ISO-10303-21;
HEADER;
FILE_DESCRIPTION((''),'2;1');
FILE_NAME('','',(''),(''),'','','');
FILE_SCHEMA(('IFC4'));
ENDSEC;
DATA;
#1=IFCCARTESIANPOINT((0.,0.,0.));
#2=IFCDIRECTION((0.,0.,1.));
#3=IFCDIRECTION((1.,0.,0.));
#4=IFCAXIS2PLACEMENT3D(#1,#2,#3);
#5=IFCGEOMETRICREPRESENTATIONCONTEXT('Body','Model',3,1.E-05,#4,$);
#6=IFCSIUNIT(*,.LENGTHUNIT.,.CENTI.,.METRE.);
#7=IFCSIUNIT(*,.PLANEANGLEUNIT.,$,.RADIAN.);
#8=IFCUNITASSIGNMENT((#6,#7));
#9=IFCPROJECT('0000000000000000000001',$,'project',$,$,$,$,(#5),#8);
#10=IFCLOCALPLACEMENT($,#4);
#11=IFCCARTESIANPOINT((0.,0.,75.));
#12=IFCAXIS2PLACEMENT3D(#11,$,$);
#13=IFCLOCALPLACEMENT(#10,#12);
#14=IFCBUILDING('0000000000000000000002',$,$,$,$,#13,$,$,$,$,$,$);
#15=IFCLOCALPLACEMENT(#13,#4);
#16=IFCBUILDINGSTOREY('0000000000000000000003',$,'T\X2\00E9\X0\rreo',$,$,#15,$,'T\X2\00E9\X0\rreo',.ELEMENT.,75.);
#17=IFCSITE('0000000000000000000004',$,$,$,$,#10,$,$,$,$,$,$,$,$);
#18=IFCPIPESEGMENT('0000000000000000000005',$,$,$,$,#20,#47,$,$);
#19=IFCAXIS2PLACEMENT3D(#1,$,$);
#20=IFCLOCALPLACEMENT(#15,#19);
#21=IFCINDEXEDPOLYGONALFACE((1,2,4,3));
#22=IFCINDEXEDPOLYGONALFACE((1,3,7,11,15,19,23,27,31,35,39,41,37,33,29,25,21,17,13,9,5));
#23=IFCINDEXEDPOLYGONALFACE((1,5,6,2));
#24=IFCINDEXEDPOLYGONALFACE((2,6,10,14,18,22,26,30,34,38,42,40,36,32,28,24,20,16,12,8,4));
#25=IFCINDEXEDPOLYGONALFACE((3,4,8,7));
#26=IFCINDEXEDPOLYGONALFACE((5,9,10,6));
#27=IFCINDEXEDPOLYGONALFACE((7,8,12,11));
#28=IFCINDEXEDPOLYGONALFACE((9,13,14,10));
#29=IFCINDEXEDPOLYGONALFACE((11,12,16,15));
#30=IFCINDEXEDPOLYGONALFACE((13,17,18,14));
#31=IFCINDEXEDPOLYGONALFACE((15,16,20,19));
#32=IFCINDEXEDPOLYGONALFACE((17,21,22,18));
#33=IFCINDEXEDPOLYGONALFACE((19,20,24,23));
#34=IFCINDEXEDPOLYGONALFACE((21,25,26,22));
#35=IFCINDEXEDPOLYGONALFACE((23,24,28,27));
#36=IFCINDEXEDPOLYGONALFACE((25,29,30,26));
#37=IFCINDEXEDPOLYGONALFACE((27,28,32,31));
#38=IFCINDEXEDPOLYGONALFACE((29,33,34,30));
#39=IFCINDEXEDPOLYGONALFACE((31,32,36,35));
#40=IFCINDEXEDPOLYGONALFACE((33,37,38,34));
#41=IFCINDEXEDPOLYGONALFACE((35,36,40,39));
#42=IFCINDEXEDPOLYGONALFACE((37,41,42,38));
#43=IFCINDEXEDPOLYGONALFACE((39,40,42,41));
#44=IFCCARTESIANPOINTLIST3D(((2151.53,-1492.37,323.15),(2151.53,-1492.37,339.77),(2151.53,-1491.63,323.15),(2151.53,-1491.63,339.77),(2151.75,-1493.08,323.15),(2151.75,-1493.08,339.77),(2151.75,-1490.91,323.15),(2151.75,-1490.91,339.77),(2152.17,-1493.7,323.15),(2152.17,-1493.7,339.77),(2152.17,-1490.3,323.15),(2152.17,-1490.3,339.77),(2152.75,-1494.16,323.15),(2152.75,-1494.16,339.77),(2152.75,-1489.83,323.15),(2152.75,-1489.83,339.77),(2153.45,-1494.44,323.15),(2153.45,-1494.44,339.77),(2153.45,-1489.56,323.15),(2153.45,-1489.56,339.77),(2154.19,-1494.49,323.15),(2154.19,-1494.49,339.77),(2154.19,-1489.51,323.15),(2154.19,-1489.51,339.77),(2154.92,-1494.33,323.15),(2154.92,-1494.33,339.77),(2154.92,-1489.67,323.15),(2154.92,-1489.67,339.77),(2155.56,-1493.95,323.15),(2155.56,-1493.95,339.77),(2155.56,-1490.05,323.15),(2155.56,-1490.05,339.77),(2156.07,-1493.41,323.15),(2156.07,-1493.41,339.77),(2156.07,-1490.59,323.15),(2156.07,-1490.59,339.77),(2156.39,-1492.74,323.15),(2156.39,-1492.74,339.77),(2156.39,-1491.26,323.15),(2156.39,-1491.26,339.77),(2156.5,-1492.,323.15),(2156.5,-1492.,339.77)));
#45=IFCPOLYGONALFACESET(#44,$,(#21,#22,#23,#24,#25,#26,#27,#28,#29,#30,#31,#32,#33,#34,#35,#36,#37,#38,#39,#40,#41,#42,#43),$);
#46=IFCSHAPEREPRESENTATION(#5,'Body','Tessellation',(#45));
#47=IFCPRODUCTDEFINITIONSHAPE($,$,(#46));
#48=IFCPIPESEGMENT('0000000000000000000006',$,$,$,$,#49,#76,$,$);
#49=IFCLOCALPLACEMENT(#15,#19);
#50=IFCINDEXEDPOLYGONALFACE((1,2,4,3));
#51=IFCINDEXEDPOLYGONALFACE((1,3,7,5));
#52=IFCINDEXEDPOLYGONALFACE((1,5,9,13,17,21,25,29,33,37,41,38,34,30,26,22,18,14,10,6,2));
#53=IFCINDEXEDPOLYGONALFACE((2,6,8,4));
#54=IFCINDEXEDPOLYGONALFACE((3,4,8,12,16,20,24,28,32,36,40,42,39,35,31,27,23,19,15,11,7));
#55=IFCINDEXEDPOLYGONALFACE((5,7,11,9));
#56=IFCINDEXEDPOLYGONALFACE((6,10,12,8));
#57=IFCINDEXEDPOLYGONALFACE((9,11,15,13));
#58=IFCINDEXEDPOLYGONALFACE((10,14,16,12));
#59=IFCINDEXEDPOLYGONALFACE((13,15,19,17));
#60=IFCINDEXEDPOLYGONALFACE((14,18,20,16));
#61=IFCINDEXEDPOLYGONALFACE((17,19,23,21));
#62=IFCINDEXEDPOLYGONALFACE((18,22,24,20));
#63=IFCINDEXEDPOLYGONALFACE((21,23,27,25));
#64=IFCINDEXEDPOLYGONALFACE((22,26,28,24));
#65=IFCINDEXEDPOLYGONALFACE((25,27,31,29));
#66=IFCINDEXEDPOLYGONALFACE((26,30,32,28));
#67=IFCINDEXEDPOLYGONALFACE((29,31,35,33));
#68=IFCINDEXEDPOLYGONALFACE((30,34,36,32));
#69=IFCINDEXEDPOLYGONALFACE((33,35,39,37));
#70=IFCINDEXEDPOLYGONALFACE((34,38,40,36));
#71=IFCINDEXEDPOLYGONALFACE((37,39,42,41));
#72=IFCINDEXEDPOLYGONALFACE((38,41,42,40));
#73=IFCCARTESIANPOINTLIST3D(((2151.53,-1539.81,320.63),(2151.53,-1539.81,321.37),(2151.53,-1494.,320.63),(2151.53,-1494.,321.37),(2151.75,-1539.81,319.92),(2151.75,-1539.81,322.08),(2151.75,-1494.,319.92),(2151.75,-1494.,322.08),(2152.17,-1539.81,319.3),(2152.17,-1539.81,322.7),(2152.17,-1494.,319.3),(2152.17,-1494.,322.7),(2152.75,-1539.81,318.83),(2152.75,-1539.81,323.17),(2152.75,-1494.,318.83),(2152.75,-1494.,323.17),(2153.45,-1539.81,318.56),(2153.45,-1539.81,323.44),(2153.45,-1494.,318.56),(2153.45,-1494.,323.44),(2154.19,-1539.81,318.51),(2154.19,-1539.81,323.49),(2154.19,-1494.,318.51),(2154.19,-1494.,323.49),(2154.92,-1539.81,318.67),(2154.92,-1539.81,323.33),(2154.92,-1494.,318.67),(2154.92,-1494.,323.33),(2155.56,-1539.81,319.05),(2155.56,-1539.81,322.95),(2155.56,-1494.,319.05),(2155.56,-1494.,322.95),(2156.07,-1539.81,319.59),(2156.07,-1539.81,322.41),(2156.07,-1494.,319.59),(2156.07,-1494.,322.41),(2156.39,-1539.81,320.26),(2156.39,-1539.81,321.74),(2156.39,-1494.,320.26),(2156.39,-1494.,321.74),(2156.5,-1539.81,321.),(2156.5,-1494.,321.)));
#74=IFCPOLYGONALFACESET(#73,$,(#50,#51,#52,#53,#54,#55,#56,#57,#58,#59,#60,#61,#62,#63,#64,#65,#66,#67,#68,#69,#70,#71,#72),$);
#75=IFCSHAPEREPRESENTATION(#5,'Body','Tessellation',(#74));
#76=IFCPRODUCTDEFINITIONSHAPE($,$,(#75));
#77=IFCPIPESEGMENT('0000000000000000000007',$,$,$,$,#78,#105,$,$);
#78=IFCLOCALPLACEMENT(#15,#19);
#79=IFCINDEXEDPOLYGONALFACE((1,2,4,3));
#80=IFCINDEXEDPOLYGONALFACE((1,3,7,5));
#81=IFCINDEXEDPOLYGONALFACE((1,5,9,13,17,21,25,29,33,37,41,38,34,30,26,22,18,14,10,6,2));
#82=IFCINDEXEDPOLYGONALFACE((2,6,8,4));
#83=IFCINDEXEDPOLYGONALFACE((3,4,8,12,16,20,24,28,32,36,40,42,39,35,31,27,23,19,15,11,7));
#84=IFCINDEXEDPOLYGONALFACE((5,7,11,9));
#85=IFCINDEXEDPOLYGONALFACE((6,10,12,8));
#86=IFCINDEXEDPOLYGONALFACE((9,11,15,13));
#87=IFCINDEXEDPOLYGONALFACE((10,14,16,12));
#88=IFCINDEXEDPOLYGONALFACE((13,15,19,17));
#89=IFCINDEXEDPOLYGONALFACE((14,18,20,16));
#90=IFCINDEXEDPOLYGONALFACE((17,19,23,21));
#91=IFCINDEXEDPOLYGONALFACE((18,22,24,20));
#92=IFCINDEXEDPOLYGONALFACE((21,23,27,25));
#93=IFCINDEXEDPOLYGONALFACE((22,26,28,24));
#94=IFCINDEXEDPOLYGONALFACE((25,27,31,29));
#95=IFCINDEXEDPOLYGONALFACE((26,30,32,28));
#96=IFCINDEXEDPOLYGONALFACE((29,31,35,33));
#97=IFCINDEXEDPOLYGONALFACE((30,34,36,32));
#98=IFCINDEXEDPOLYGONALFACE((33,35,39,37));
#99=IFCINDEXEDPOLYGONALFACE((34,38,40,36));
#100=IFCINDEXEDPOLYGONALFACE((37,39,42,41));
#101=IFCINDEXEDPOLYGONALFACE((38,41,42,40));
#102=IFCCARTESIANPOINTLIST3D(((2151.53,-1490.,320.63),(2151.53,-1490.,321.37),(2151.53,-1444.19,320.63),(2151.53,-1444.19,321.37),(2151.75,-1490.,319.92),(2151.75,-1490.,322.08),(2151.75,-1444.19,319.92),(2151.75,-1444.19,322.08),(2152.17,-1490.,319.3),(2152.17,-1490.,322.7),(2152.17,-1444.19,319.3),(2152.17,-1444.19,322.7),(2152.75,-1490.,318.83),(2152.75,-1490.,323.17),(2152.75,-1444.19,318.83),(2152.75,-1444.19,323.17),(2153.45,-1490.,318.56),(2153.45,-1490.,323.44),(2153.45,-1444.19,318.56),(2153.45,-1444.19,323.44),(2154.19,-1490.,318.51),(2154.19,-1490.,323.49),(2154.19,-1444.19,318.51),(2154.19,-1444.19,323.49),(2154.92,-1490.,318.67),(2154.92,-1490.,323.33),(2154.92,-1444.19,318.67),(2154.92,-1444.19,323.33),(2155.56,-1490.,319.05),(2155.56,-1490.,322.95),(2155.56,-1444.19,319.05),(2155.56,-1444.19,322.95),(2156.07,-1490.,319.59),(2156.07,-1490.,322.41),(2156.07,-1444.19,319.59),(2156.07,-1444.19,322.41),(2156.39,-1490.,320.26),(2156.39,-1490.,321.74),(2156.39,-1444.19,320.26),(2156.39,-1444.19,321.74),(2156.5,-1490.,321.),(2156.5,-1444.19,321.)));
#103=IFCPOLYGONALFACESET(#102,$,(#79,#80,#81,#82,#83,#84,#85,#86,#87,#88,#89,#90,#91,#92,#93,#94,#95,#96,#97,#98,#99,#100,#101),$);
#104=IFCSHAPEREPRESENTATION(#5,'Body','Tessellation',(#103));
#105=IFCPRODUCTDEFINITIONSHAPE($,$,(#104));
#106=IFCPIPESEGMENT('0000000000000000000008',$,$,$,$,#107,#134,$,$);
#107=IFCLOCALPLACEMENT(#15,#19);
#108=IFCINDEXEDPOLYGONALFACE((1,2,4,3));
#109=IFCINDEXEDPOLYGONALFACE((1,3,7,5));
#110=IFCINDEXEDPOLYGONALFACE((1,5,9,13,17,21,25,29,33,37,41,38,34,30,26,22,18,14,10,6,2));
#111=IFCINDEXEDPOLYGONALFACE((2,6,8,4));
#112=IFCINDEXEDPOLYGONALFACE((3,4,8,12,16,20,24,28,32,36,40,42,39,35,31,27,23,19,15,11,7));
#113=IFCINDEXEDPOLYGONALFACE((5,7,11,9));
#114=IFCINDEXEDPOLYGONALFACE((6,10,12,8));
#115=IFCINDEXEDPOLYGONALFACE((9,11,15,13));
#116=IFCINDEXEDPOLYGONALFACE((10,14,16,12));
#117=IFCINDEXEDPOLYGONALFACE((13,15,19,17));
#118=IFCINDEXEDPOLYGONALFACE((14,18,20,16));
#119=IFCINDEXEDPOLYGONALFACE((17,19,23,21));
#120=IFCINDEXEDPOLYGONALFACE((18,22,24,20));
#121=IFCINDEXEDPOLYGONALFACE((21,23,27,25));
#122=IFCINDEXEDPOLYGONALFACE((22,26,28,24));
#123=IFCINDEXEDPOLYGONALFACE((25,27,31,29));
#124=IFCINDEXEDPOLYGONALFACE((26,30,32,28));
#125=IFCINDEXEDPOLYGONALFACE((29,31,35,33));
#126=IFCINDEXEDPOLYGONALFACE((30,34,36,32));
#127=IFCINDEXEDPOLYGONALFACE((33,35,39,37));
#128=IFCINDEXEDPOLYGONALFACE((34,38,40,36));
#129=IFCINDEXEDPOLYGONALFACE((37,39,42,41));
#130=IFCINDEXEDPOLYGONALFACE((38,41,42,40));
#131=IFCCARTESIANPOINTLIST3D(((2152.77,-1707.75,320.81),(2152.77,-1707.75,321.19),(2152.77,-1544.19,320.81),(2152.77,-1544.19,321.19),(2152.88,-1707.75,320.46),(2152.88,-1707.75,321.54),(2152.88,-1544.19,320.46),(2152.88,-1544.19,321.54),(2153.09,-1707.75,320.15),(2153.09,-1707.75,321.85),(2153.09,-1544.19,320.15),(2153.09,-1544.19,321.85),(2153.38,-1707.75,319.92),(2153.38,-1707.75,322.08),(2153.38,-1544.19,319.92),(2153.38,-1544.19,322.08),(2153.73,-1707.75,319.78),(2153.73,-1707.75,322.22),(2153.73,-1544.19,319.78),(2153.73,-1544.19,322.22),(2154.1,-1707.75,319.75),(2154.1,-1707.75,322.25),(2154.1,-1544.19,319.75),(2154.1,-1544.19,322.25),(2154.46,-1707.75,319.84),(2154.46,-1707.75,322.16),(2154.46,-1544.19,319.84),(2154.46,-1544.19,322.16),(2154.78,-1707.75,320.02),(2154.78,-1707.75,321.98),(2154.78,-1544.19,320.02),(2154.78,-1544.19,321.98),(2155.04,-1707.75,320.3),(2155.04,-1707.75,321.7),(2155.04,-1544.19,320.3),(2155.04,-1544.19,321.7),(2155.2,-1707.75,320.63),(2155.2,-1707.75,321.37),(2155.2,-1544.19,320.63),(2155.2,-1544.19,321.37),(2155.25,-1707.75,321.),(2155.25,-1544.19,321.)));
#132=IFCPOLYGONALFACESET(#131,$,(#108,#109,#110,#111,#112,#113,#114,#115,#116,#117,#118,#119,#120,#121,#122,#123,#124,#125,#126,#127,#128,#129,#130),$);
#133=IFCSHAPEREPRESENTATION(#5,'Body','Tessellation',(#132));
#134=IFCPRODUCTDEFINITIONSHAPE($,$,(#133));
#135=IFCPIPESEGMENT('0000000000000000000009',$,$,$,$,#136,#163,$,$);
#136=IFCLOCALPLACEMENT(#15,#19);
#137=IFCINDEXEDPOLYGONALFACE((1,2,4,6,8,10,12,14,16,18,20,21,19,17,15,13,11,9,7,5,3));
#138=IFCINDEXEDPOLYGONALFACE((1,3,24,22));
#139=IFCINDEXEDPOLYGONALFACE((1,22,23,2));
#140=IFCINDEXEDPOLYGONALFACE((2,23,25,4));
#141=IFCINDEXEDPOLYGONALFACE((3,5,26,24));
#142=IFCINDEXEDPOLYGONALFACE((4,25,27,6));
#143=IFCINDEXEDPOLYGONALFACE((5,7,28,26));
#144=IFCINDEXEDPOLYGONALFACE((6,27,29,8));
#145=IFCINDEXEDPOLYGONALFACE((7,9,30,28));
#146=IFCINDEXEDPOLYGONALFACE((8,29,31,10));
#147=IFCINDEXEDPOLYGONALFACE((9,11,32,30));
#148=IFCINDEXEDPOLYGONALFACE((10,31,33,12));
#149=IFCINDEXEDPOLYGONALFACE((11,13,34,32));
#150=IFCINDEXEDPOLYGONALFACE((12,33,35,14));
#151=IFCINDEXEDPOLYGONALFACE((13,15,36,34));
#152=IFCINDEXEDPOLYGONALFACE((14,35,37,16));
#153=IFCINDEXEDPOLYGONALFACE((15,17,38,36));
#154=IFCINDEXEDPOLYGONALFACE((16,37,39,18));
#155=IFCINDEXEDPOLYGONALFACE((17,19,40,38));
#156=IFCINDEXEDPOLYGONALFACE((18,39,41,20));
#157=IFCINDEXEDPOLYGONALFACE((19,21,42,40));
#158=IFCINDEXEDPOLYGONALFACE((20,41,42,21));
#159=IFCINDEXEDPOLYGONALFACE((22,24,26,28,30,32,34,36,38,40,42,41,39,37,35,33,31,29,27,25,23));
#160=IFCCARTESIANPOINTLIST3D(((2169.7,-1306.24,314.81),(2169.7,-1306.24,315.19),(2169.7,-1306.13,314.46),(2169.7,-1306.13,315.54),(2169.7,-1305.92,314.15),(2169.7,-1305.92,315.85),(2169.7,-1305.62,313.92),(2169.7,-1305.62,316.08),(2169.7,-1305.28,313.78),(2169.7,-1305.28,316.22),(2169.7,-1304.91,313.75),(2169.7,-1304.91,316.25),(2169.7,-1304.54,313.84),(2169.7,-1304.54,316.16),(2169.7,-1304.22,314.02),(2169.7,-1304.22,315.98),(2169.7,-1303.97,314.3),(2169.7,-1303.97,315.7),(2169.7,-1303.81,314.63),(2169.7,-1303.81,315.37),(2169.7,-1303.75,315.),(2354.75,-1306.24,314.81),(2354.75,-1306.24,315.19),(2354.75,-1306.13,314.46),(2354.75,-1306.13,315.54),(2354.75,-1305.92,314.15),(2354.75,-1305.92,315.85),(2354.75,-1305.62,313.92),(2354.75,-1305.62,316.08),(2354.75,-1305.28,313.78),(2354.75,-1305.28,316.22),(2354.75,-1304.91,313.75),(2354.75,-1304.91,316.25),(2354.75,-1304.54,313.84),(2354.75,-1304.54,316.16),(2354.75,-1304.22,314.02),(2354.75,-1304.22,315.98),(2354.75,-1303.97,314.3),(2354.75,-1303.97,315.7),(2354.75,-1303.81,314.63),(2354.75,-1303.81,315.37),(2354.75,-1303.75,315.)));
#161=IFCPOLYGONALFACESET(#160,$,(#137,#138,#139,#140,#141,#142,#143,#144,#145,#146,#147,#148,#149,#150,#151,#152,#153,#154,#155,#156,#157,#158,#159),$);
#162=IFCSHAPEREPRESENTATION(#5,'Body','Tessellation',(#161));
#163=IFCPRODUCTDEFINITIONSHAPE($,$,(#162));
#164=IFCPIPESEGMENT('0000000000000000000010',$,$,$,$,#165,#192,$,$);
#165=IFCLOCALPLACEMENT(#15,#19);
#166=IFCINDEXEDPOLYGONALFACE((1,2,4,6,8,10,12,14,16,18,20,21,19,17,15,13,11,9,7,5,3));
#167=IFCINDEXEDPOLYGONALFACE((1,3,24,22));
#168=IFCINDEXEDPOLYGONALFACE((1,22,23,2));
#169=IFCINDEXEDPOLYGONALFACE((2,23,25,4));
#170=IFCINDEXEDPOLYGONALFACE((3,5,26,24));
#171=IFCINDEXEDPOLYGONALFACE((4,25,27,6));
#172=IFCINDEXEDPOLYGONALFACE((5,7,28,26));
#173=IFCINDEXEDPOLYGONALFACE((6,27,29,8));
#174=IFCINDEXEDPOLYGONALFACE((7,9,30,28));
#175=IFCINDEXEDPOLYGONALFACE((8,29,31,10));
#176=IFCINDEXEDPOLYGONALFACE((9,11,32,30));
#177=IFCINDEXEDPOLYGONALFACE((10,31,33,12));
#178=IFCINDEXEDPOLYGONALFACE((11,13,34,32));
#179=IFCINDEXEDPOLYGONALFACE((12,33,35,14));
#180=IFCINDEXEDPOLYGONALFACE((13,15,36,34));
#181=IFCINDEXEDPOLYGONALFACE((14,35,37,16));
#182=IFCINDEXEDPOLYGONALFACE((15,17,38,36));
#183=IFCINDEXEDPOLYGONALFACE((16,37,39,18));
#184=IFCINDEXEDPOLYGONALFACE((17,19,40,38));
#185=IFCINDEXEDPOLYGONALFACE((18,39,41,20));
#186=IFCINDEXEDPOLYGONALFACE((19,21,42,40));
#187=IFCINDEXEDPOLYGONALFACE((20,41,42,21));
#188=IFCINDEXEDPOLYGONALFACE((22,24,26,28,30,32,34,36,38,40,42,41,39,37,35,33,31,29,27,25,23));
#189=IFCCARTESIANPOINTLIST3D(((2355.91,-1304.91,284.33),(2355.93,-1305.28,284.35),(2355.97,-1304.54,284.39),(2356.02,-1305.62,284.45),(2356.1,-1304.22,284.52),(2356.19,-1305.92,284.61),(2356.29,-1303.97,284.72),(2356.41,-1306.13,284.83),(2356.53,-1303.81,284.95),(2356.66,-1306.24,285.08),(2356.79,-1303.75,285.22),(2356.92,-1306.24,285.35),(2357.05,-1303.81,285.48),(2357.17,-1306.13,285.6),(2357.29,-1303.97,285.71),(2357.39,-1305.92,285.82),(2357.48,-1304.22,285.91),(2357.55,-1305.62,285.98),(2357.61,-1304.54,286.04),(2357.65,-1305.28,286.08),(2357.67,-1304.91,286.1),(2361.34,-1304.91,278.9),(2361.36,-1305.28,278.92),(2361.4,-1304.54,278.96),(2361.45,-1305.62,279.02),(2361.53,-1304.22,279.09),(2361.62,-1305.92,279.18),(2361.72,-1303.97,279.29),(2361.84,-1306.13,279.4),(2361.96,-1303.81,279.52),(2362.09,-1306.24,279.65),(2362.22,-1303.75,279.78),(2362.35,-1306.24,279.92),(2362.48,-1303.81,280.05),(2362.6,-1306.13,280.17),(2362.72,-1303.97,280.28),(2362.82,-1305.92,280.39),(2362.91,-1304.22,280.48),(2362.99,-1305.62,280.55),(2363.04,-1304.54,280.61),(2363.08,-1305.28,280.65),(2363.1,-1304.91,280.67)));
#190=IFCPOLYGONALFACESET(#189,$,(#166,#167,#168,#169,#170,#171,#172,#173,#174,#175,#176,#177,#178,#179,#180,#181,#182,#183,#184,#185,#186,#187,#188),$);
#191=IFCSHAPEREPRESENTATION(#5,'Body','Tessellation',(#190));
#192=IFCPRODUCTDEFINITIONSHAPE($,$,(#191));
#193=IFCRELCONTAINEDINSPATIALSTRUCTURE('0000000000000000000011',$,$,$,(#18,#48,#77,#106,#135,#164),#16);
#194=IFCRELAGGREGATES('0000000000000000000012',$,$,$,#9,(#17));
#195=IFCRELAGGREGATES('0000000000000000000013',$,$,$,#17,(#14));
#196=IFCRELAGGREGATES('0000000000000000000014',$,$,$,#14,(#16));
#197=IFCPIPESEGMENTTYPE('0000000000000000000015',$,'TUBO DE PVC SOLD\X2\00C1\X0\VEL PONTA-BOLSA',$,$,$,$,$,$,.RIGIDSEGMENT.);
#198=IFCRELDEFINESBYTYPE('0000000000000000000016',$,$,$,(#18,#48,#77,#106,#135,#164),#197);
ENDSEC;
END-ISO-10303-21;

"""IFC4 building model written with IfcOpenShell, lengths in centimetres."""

from ifc_helpers import new_model, si_unit, frame, origin_with_axes, origin_2d_with_axis, place, context, project, spatial, circle, extrude, type_object, element, save


model = new_model("IFC4")

# Units and contexts
model_context = context("Model", 3, precision=1e-05, world=origin_with_axes(), identifier="Body")
ifc_project = project(units=[si_unit("LENGTHUNIT", "METRE", prefix="CENTI"), si_unit("PLANEANGLEUNIT", "RADIAN")], contexts=[model_context])

# Site, building, storey
site_placement = place(None, origin_with_axes())
site = spatial("IfcSite", under=ifc_project, at=site_placement)
building_placement = place(site_placement, frame((0.0, 0.0, 75.0)))
building = spatial("IfcBuilding", under=site, at=building_placement)
storey_placement = place(building_placement, origin_with_axes())
storey = spatial("IfcBuildingStorey", under=building, at=storey_placement, Name="Térreo", LongName="Térreo", CompositionType="ELEMENT", Elevation=75.0)

# Pipe segments
pipe_segment_type_1 = type_object("IfcPipeSegmentType", Name="TUBO DE PVC SOLDÁVEL PONTA-BOLSA", PredefinedType="RIGIDSEGMENT")
pipe_segment_1_placement = place(storey_placement, frame((2154.0, -1492.0, 339.77), z_axis=(0.0, 0.0, 1.0), x_axis=(1.0, 0.0, 0.0)))
element("IfcPipeSegment", 1, at=pipe_segment_1_placement, inside=storey, type_object=pipe_segment_type_1, context=model_context, shape_type="SolidModel", body=[
    extrude(circle(Radius=2.5, at=origin_2d_with_axis()), frame((0.0, 0.0, 0.0), z_axis=(0.0, 0.0, -1.0), x_axis=(1.0, 0.0, 0.0)), (0.0, 0.0, 1.0), 16.62),
])
pipe_segment_2_placement = place(storey_placement, frame((2154.0, -1516.9, 323.5), z_axis=(0.0, 0.0, 1.0), x_axis=(1.0, 0.0, 0.0)))
element("IfcPipeSegment", 2, at=pipe_segment_2_placement, inside=storey, type_object=pipe_segment_type_1, context=model_context, shape_type="SolidModel", body=[
    extrude(circle(Radius=2.5, at=origin_2d_with_axis()), frame((0.0, 22.91, -2.5), z_axis=(0.0, -1.0, 0.0), x_axis=(1.0, 0.0, 0.0)), (0.0, 0.0, 1.0), 45.82),
])
pipe_segment_3_placement = place(storey_placement, frame((2154.0, -1467.1, 323.5), z_axis=(0.0, 0.0, 1.0), x_axis=(1.0, 0.0, 0.0)))
element("IfcPipeSegment", 3, at=pipe_segment_3_placement, inside=storey, type_object=pipe_segment_type_1, context=model_context, shape_type="SolidModel", body=[
    extrude(circle(Radius=2.5, at=origin_2d_with_axis()), frame((0.0, -22.91, -2.5), z_axis=(0.0, 1.0, 0.0), x_axis=(1.0, 0.0, 0.0)), (0.0, 0.0, 1.0), 45.82),
])
pipe_segment_4_placement = place(storey_placement, frame((2154.0, -1625.97, 322.25), z_axis=(0.0, 0.0, 1.0), x_axis=(1.0, 0.0, 0.0)))
element("IfcPipeSegment", 4, at=pipe_segment_4_placement, inside=storey, type_object=pipe_segment_type_1, context=model_context, shape_type="SolidModel", body=[
    extrude(circle(Radius=1.25, at=origin_2d_with_axis()), frame((0.0, 81.78, -1.25), z_axis=(0.0, -1.0, 0.0), x_axis=(1.0, 0.0, 0.0)), (0.0, 0.0, 1.0), 163.56),
])
pipe_segment_5_placement = place(storey_placement, frame((2262.23, -1305.0, 316.25), z_axis=(0.0, 0.0, 1.0), x_axis=(1.0, 0.0, 0.0)))
element("IfcPipeSegment", 5, at=pipe_segment_5_placement, inside=storey, type_object=pipe_segment_type_1, context=model_context, shape_type="SolidModel", body=[
    extrude(circle(Radius=1.25, at=origin_2d_with_axis()), frame((-92.53, 0.0, -1.25), z_axis=(1.0, 0.0, 0.0), x_axis=(0.0, 1.0, 0.0)), (0.0, 0.0, 1.0), 185.05),
])
pipe_segment_6_placement = place(storey_placement, frame((2359.5, -1305.0, 286.1), z_axis=(0.0, 0.0, 1.0), x_axis=(1.0, 0.0, 0.0)))
element("IfcPipeSegment", 6, at=pipe_segment_6_placement, inside=storey, type_object=pipe_segment_type_1, context=model_context, shape_type="SolidModel", body=[
    extrude(circle(Radius=1.25, at=origin_2d_with_axis()), frame((-2.72, 0.0, -0.88), z_axis=(0.707107, 0.0, -0.707107), x_axis=(0.0, 1.0, 0.0)), (0.0, 0.0, 1.0), 7.68),
])

save(model, "model.ifc")
